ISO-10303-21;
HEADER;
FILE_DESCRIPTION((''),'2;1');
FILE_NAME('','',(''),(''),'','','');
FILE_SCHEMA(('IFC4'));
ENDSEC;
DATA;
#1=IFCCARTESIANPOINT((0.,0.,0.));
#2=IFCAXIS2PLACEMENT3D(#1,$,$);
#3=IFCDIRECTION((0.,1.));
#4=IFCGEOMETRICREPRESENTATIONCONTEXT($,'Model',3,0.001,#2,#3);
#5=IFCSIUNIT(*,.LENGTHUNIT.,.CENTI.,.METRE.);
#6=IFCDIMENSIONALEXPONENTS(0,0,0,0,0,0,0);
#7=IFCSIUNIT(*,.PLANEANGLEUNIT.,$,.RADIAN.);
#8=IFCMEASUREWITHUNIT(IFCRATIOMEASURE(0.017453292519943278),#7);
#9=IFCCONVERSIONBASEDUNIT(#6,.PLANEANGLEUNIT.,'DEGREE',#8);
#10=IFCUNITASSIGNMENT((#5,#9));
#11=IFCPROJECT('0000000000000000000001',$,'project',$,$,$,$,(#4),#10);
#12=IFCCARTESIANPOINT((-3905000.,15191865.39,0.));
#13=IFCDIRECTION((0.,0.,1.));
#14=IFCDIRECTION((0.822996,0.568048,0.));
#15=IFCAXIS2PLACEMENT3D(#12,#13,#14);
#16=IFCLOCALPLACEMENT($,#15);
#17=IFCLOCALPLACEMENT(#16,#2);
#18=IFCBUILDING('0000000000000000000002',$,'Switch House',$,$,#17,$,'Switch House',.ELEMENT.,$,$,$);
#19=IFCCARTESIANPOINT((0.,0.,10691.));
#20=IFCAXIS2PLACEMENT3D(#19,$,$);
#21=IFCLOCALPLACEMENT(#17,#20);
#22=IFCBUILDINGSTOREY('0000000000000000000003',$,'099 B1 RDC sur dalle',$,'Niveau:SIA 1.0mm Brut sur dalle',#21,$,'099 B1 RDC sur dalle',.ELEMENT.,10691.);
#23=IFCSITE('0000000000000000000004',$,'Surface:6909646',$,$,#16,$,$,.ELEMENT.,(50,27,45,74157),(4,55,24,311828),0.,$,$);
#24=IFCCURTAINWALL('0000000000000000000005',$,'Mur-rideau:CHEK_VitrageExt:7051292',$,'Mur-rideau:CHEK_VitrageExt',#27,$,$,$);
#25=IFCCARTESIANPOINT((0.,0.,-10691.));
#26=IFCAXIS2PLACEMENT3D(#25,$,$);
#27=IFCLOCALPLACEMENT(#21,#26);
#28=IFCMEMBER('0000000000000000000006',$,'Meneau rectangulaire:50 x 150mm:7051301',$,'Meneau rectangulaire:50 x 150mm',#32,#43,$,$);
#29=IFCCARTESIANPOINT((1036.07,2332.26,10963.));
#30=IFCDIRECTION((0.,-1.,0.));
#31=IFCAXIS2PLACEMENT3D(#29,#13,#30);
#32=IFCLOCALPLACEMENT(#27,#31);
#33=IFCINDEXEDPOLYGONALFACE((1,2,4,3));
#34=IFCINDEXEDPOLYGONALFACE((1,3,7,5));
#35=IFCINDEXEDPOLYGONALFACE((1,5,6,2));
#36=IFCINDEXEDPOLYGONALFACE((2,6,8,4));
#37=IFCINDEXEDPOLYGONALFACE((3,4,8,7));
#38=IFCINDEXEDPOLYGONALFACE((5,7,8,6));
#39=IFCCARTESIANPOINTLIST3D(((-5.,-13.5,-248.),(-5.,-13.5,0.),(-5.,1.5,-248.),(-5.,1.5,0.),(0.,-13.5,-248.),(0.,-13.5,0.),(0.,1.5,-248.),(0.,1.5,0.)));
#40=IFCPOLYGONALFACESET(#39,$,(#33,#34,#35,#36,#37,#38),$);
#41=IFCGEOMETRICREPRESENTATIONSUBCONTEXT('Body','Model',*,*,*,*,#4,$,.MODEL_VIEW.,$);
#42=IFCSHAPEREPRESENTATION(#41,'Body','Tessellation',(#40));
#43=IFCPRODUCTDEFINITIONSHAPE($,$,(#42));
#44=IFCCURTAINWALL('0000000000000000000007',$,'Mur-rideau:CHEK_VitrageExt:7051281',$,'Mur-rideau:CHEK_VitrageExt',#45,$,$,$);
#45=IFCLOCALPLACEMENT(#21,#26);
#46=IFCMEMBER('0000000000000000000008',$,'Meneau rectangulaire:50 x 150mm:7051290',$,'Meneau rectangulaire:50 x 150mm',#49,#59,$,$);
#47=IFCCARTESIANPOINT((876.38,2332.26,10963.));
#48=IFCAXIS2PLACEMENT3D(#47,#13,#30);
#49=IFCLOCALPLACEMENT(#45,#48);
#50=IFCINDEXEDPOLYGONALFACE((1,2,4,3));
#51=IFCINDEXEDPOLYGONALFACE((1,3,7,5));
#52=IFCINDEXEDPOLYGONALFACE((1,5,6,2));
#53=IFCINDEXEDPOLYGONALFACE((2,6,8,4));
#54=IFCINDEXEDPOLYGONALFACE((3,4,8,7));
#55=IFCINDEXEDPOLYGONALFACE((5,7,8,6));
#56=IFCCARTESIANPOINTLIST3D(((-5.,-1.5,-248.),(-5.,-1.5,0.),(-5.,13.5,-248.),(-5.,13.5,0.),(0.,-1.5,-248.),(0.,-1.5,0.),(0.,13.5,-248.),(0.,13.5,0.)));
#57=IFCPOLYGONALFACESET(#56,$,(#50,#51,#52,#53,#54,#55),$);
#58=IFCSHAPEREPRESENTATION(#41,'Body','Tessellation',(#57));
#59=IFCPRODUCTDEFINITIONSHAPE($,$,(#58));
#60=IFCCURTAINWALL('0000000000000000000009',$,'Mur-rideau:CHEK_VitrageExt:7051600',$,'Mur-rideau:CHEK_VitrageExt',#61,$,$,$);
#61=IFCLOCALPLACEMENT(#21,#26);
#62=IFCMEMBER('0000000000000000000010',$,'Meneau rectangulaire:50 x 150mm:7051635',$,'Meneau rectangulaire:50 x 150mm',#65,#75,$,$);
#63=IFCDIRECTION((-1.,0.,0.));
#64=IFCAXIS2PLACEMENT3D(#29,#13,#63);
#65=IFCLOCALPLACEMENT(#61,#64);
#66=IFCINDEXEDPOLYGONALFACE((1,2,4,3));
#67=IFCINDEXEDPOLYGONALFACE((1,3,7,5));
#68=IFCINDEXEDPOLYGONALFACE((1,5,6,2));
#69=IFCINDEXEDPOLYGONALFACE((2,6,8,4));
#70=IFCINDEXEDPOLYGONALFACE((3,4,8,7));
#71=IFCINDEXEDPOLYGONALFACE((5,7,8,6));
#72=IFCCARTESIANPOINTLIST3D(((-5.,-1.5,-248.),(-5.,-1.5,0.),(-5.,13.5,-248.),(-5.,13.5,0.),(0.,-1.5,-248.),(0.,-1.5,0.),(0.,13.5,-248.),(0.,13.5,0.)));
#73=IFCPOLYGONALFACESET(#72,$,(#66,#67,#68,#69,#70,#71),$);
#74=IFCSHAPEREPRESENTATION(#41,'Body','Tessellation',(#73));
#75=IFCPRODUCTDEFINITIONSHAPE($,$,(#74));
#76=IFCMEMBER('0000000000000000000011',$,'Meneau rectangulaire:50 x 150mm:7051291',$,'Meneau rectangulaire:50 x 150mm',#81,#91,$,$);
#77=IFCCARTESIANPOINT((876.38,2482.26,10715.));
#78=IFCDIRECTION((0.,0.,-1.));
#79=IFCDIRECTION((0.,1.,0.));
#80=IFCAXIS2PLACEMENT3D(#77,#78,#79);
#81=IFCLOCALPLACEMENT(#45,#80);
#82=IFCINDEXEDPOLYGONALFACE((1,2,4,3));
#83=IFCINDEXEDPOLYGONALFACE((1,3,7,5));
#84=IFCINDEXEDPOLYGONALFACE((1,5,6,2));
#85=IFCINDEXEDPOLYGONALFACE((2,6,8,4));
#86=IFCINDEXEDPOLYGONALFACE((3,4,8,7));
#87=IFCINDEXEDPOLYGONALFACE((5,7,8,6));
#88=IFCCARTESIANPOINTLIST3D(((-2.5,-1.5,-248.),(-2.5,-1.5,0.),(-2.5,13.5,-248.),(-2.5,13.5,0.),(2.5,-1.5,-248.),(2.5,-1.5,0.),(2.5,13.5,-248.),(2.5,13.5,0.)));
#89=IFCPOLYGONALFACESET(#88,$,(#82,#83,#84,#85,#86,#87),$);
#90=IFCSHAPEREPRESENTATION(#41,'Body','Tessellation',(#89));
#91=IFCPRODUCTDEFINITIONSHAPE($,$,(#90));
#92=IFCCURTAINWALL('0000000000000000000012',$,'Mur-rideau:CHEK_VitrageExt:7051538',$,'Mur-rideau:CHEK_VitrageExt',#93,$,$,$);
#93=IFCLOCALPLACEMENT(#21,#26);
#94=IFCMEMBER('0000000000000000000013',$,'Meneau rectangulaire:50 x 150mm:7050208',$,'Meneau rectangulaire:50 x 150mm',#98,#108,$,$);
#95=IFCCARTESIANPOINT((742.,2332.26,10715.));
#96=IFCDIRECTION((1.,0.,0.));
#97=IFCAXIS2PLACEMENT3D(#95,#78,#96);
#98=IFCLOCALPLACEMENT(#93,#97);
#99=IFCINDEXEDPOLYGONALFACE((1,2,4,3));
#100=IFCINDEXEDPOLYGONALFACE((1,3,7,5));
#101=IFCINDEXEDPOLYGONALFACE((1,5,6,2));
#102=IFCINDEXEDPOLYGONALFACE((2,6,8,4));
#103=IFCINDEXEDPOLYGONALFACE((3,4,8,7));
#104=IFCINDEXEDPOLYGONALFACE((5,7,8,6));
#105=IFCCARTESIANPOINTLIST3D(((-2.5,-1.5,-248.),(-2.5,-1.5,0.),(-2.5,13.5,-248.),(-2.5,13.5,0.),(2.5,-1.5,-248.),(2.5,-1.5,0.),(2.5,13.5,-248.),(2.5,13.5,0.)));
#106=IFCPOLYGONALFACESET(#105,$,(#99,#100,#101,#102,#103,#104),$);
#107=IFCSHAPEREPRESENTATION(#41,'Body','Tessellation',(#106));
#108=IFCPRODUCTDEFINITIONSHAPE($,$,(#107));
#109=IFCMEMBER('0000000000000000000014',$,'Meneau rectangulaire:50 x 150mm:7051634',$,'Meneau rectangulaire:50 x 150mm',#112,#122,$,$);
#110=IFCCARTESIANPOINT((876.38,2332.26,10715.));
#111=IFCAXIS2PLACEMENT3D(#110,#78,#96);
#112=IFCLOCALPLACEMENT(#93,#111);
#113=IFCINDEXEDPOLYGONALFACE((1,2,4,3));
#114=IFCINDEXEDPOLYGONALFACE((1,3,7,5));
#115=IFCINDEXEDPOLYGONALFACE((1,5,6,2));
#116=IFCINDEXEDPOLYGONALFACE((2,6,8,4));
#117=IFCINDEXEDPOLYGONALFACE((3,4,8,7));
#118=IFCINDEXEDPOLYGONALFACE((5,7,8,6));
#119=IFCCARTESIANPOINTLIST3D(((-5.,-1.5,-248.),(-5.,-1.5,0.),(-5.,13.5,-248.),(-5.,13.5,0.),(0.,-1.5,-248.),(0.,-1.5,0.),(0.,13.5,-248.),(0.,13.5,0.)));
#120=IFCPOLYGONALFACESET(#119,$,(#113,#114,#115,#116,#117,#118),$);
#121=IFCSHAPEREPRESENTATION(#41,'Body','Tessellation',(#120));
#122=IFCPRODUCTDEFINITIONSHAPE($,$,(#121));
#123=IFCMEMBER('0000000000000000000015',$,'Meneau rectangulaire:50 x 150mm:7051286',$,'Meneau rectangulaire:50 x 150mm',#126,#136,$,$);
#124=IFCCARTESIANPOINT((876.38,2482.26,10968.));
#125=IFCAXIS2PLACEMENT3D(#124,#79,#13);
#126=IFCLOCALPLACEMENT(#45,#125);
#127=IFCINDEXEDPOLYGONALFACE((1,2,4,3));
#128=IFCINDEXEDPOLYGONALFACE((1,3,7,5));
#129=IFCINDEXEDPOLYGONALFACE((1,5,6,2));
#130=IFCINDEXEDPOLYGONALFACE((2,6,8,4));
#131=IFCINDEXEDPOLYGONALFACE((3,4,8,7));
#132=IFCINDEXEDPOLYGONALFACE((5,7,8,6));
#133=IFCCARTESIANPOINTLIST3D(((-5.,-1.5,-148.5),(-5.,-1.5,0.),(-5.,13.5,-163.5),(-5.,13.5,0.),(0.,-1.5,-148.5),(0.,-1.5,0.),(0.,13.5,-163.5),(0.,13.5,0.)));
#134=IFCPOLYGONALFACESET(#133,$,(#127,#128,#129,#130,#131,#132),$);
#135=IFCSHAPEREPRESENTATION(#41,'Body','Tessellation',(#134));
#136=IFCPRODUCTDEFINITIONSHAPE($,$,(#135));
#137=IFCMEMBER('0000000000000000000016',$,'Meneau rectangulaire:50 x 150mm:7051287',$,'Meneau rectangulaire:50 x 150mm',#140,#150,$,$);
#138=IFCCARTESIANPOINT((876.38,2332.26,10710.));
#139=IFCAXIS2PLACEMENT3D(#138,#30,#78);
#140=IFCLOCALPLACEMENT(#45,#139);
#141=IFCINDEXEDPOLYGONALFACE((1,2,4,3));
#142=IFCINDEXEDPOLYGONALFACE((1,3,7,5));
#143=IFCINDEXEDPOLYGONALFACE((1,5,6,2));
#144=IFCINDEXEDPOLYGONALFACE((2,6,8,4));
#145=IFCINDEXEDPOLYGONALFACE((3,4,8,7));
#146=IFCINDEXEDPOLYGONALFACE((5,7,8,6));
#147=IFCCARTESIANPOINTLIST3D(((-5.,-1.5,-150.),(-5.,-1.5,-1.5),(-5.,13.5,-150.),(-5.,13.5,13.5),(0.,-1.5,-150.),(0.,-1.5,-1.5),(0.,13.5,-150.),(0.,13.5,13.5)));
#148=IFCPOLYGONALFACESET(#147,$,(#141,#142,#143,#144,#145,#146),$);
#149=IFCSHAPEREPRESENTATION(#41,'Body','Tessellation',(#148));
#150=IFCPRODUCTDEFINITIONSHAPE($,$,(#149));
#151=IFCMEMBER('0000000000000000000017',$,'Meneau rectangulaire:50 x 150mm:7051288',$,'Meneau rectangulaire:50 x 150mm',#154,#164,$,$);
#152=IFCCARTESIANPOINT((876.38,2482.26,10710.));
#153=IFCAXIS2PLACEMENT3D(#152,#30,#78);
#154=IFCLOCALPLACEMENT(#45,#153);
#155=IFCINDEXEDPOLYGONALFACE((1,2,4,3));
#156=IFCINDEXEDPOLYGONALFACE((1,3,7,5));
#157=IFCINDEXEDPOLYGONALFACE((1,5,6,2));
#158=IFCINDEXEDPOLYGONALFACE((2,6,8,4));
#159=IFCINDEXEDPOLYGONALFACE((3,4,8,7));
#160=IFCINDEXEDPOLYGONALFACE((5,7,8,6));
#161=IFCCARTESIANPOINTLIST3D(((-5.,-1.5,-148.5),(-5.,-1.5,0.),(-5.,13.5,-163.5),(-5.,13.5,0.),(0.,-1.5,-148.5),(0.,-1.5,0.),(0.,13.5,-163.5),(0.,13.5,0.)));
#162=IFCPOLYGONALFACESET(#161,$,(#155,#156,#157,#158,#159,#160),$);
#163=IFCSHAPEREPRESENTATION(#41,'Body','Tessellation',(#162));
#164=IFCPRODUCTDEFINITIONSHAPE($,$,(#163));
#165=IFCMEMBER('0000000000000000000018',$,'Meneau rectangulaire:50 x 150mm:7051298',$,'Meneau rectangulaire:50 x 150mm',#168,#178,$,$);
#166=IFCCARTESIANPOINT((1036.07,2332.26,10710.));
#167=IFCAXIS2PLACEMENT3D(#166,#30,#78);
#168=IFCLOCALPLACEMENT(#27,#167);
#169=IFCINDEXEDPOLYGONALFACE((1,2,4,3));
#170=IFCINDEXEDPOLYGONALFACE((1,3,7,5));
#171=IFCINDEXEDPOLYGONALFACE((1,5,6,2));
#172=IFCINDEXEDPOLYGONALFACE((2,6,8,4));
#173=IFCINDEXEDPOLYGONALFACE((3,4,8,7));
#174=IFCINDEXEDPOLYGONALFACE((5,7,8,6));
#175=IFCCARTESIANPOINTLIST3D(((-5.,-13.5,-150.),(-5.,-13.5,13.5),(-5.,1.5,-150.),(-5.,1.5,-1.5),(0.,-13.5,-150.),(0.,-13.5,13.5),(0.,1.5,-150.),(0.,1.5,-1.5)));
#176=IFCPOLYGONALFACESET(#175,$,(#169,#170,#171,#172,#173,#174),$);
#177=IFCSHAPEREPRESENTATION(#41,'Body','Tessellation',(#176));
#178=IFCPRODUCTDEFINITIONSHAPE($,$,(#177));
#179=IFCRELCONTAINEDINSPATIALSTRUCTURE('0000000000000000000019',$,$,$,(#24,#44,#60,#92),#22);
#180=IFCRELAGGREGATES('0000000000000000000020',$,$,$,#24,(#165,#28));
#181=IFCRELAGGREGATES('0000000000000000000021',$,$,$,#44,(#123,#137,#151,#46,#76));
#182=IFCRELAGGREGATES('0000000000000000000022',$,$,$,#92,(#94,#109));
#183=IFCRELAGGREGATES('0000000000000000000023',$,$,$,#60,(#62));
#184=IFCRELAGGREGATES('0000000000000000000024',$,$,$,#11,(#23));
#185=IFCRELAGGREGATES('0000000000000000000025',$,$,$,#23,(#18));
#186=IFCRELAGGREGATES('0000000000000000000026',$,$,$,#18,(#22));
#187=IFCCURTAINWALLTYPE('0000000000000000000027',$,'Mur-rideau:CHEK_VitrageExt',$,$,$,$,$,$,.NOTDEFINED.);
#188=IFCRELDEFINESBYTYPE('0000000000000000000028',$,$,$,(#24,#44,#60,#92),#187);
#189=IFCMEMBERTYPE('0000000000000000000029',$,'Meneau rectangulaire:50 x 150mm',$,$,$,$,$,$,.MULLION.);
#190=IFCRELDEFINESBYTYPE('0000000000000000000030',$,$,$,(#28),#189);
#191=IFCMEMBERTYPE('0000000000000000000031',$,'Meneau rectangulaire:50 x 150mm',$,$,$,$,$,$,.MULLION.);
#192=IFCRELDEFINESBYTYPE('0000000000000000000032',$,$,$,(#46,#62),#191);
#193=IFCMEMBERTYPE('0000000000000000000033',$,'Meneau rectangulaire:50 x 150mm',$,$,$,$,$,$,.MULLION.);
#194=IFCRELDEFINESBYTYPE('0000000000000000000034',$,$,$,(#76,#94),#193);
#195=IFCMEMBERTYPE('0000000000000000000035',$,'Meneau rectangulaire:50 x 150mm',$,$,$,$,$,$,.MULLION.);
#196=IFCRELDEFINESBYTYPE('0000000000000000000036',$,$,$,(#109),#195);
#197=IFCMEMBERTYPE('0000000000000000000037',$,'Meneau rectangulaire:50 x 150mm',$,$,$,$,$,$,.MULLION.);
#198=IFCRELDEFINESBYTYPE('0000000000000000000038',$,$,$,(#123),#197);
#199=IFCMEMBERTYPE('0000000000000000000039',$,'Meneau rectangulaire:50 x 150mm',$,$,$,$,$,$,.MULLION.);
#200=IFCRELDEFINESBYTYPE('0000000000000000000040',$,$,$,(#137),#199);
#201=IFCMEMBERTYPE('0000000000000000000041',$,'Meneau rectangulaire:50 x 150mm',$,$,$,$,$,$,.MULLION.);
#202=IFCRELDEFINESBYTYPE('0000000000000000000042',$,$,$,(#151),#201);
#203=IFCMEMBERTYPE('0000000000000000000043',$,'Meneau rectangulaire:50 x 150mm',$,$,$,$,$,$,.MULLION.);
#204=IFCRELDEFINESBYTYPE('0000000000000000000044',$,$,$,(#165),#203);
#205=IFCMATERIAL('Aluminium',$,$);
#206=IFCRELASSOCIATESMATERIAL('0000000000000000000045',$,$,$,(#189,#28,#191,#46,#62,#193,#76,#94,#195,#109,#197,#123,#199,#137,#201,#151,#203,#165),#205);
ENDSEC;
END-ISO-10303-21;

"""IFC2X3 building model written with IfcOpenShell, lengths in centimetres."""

from ifc_helpers import new_model, entity, si_unit, converted_unit, direction, frame, origin, origin_2d_with_axis, place, context, subcontext, project, spatial, rectangle, extrude, clip, halfspace, source, transform, mapped, material, type_object, type_shapes, element, aggregate, save


model = new_model("IFC2X3")

# Units and contexts
model_context = context("Model", 3, precision=0.001, world=origin(), true_north=direction((0.0, 1.0)))
body_context = subcontext(model_context, "Body", "Model", "MODEL_VIEW")
ifc_project = project(units=[si_unit("LENGTHUNIT", "METRE", prefix="CENTI"), converted_unit("PLANEANGLEUNIT", "DEGREE", entity("IfcRatioMeasure", 0.017453292519943278), si_unit("PLANEANGLEUNIT", "RADIAN"), dimensions=[0, 0, 0, 0, 0, 0, 0])], contexts=[model_context])

# Site, building, storey
site_placement = place(None, frame((-3905000.0, 15191865.39, 0.0), z_axis=(0.0, 0.0, 1.0), x_axis=(0.822996, 0.568048, 0.0)))
site = spatial("IfcSite", under=ifc_project, at=site_placement, Name="Surface:6909646", CompositionType="ELEMENT", RefLatitude=(50, 27, 45, 74157), RefLongitude=(4, 55, 24, 311828), RefElevation=0.0)
building_placement = place(site_placement, origin())
building = spatial("IfcBuilding", under=site, at=building_placement, Name="Switch House", LongName="Switch House", CompositionType="ELEMENT")
storey_placement = place(building_placement, frame((0.0, 0.0, 10691.0)))
storey = spatial("IfcBuildingStorey", under=building, at=storey_placement, Name="099 B1 RDC sur dalle", ObjectType="Niveau:SIA 1.0mm Brut sur dalle", LongName="099 B1 RDC sur dalle", CompositionType="ELEMENT", Elevation=10691.0)

# Curtain walls, members
curtain_wall_type = type_object("IfcCurtainWallType", Name="Mur-rideau:CHEK_VitrageExt", PredefinedType="NOTDEFINED")
curtain_wall_1_placement = place(storey_placement, frame((0.0, 0.0, -10691.0)))
curtain_wall_1 = element("IfcCurtainWall", 1, at=curtain_wall_1_placement, inside=storey, type_object=curtain_wall_type, Name="Mur-rideau:CHEK_VitrageExt:7051292", ObjectType="Mur-rideau:CHEK_VitrageExt")
ifc_material_1 = material(Name="Aluminium")
member_type_1 = type_object("IfcMemberType", Name="Meneau rectangulaire:50 x 150mm", PredefinedType="MULLION", material=ifc_material_1)
shared_shape_1 = source(origin(), body_context, "Body", "SweptSolid", [
    extrude(rectangle(XDim=15.0, YDim=5.0, at=origin_2d_with_axis()), frame((-2.5, -6.0, -248.0), z_axis=(0.0, 0.0, 1.0), x_axis=(0.0, -1.0, 0.0)), (0.0, 0.0, 1.0), 248.0),
])
type_shapes(member_type_1, [shared_shape_1])
member_1_placement = place(curtain_wall_1_placement, frame((1036.07, 2332.26, 10963.0), z_axis=(0.0, 0.0, 1.0), x_axis=(0.0, -1.0, 0.0)))
member_1 = element("IfcMember", 2, at=member_1_placement, type_object=member_type_1, material=ifc_material_1, Name="Meneau rectangulaire:50 x 150mm:7051301", ObjectType="Meneau rectangulaire:50 x 150mm", context=body_context, shape_type="MappedRepresentation", body=[
    mapped(shared_shape_1, transform((0.0, 0.0, 0.0), scale=1.0)),
])
curtain_wall_2_placement = place(storey_placement, frame((0.0, 0.0, -10691.0)))
curtain_wall_2 = element("IfcCurtainWall", 3, at=curtain_wall_2_placement, inside=storey, type_object=curtain_wall_type, Name="Mur-rideau:CHEK_VitrageExt:7051281", ObjectType="Mur-rideau:CHEK_VitrageExt")
member_type_2 = type_object("IfcMemberType", Name="Meneau rectangulaire:50 x 150mm", PredefinedType="MULLION", material=ifc_material_1)
shared_shape_2 = source(origin(), body_context, "Body", "SweptSolid", [
    extrude(rectangle(XDim=15.0, YDim=5.0, at=origin_2d_with_axis()), frame((-2.5, 6.0, -248.0), z_axis=(0.0, 0.0, 1.0), x_axis=(0.0, -1.0, 0.0)), (0.0, 0.0, 1.0), 248.0),
])
type_shapes(member_type_2, [shared_shape_2])
member_2_placement = place(curtain_wall_2_placement, frame((876.38, 2332.26, 10963.0), z_axis=(0.0, 0.0, 1.0), x_axis=(0.0, -1.0, 0.0)))
member_2 = element("IfcMember", 4, at=member_2_placement, type_object=member_type_2, material=ifc_material_1, Name="Meneau rectangulaire:50 x 150mm:7051290", ObjectType="Meneau rectangulaire:50 x 150mm", context=body_context, shape_type="MappedRepresentation", body=[
    mapped(shared_shape_2, transform((0.0, 0.0, 0.0), scale=1.0)),
])
curtain_wall_3_placement = place(storey_placement, frame((0.0, 0.0, -10691.0)))
curtain_wall_3 = element("IfcCurtainWall", 5, at=curtain_wall_3_placement, inside=storey, type_object=curtain_wall_type, Name="Mur-rideau:CHEK_VitrageExt:7051600", ObjectType="Mur-rideau:CHEK_VitrageExt")
member_3_placement = place(curtain_wall_3_placement, frame((1036.07, 2332.26, 10963.0), z_axis=(0.0, 0.0, 1.0), x_axis=(-1.0, 0.0, 0.0)))
member_3 = element("IfcMember", 6, at=member_3_placement, type_object=member_type_2, material=ifc_material_1, Name="Meneau rectangulaire:50 x 150mm:7051635", ObjectType="Meneau rectangulaire:50 x 150mm", context=body_context, shape_type="MappedRepresentation", body=[
    mapped(shared_shape_2, transform((0.0, 0.0, 0.0), scale=1.0)),
])

# Member
member_type_3 = type_object("IfcMemberType", Name="Meneau rectangulaire:50 x 150mm", PredefinedType="MULLION", material=ifc_material_1)
shared_shape_3 = source(origin(), body_context, "Body", "SweptSolid", [
    extrude(rectangle(XDim=15.0, YDim=5.0, at=origin_2d_with_axis()), frame((0.0, 6.0, -248.0), z_axis=(0.0, 0.0, 1.0), x_axis=(0.0, -1.0, 0.0)), (0.0, 0.0, 1.0), 248.0),
])
type_shapes(member_type_3, [shared_shape_3])
member_4_placement = place(curtain_wall_2_placement, frame((876.38, 2482.26, 10715.0), z_axis=(0.0, 0.0, -1.0), x_axis=(0.0, 1.0, 0.0)))
member_4 = element("IfcMember", 7, at=member_4_placement, type_object=member_type_3, material=ifc_material_1, Name="Meneau rectangulaire:50 x 150mm:7051291", ObjectType="Meneau rectangulaire:50 x 150mm", context=body_context, shape_type="MappedRepresentation", body=[
    mapped(shared_shape_3, transform((0.0, 0.0, 0.0), scale=1.0)),
])

# Curtain wall, members
curtain_wall_4_placement = place(storey_placement, frame((0.0, 0.0, -10691.0)))
curtain_wall_4 = element("IfcCurtainWall", 8, at=curtain_wall_4_placement, inside=storey, type_object=curtain_wall_type, Name="Mur-rideau:CHEK_VitrageExt:7051538", ObjectType="Mur-rideau:CHEK_VitrageExt")
member_5_placement = place(curtain_wall_4_placement, frame((742.0, 2332.26, 10715.0), z_axis=(0.0, 0.0, -1.0), x_axis=(1.0, 0.0, 0.0)))
member_5 = element("IfcMember", 9, at=member_5_placement, type_object=member_type_3, material=ifc_material_1, Name="Meneau rectangulaire:50 x 150mm:7050208", ObjectType="Meneau rectangulaire:50 x 150mm", context=body_context, shape_type="MappedRepresentation", body=[
    mapped(shared_shape_3, transform((0.0, 0.0, 0.0), scale=1.0)),
])
member_type_4 = type_object("IfcMemberType", Name="Meneau rectangulaire:50 x 150mm", PredefinedType="MULLION", material=ifc_material_1)
shared_shape_4 = source(origin(), body_context, "Body", "SweptSolid", [
    extrude(rectangle(XDim=15.0, YDim=5.0, at=origin_2d_with_axis()), frame((-2.5, 6.0, -248.0), z_axis=(0.0, 0.0, 1.0), x_axis=(0.0, -1.0, 0.0)), (0.0, 0.0, 1.0), 248.0),
])
type_shapes(member_type_4, [shared_shape_4])
member_6_placement = place(curtain_wall_4_placement, frame((876.38, 2332.26, 10715.0), z_axis=(0.0, 0.0, -1.0), x_axis=(1.0, 0.0, 0.0)))
member_6 = element("IfcMember", 10, at=member_6_placement, type_object=member_type_4, material=ifc_material_1, Name="Meneau rectangulaire:50 x 150mm:7051634", ObjectType="Meneau rectangulaire:50 x 150mm", context=body_context, shape_type="MappedRepresentation", body=[
    mapped(shared_shape_4, transform((0.0, 0.0, 0.0), scale=1.0)),
])

# Members
member_type_5 = type_object("IfcMemberType", Name="Meneau rectangulaire:50 x 150mm", PredefinedType="MULLION", material=ifc_material_1)
shared_shape_5 = source(origin(), body_context, "Body", "SweptSolid", [
    clip(extrude(rectangle(XDim=15.0, YDim=5.0, at=origin_2d_with_axis()), frame((-2.5, 6.0, -163.5), z_axis=(0.0, 0.0, 1.0), x_axis=(0.0, -1.0, 0.0)), (0.0, 0.0, 1.0), 163.5), halfspace(frame((30.48, 0.0, -150.0), z_axis=(0.0, -0.707107, -0.707107), x_axis=(0.0, -0.707107, 0.707107)), False)),
])
type_shapes(member_type_5, [shared_shape_5])
member_7_placement = place(curtain_wall_2_placement, frame((876.38, 2482.26, 10968.0), z_axis=(0.0, 1.0, 0.0), x_axis=(0.0, 0.0, 1.0)))
member_7 = element("IfcMember", 11, at=member_7_placement, type_object=member_type_5, material=ifc_material_1, Name="Meneau rectangulaire:50 x 150mm:7051286", ObjectType="Meneau rectangulaire:50 x 150mm", context=body_context, shape_type="MappedRepresentation", body=[
    mapped(shared_shape_5, transform((0.0, 0.0, 0.0), scale=1.0)),
])
member_type_6 = type_object("IfcMemberType", Name="Meneau rectangulaire:50 x 150mm", PredefinedType="MULLION", material=ifc_material_1)
shared_shape_6 = source(origin(), body_context, "Body", "SweptSolid", [
    clip(extrude(rectangle(XDim=15.0, YDim=5.0, at=origin_2d_with_axis()), frame((-2.5, 6.0, -150.0), z_axis=(0.0, 0.0, 1.0), x_axis=(0.0, -1.0, 0.0)), (0.0, 0.0, 1.0), 163.5), halfspace(frame((30.48, 0.0, 0.0), z_axis=(0.0, -0.707107, 0.707107), x_axis=(0.0, -0.707107, -0.707107)), False)),
])
type_shapes(member_type_6, [shared_shape_6])
member_8_placement = place(curtain_wall_2_placement, frame((876.38, 2332.26, 10710.0), z_axis=(0.0, -1.0, 0.0), x_axis=(0.0, 0.0, -1.0)))
member_8 = element("IfcMember", 12, at=member_8_placement, type_object=member_type_6, material=ifc_material_1, Name="Meneau rectangulaire:50 x 150mm:7051287", ObjectType="Meneau rectangulaire:50 x 150mm", context=body_context, shape_type="MappedRepresentation", body=[
    mapped(shared_shape_6, transform((0.0, 0.0, 0.0), scale=1.0)),
])
member_type_7 = type_object("IfcMemberType", Name="Meneau rectangulaire:50 x 150mm", PredefinedType="MULLION", material=ifc_material_1)
shared_shape_7 = source(origin(), body_context, "Body", "SweptSolid", [
    clip(extrude(rectangle(XDim=15.0, YDim=5.0, at=origin_2d_with_axis()), frame((-2.5, 6.0, -163.5), z_axis=(0.0, 0.0, 1.0), x_axis=(0.0, -1.0, 0.0)), (0.0, 0.0, 1.0), 163.5), halfspace(frame((30.48, 0.0, -150.0), z_axis=(0.0, -0.707107, -0.707107), x_axis=(0.0, -0.707107, 0.707107)), False)),
])
type_shapes(member_type_7, [shared_shape_7])
member_9_placement = place(curtain_wall_2_placement, frame((876.38, 2482.26, 10710.0), z_axis=(0.0, -1.0, 0.0), x_axis=(0.0, 0.0, -1.0)))
member_9 = element("IfcMember", 13, at=member_9_placement, type_object=member_type_7, material=ifc_material_1, Name="Meneau rectangulaire:50 x 150mm:7051288", ObjectType="Meneau rectangulaire:50 x 150mm", context=body_context, shape_type="MappedRepresentation", body=[
    mapped(shared_shape_7, transform((0.0, 0.0, 0.0), scale=1.0)),
])
member_type_8 = type_object("IfcMemberType", Name="Meneau rectangulaire:50 x 150mm", PredefinedType="MULLION", material=ifc_material_1)
shared_shape_8 = source(origin(), body_context, "Body", "SweptSolid", [
    clip(extrude(rectangle(XDim=15.0, YDim=5.0, at=origin_2d_with_axis()), frame((-2.5, -6.0, -150.0), z_axis=(0.0, 0.0, 1.0), x_axis=(0.0, -1.0, 0.0)), (0.0, 0.0, 1.0), 163.5), halfspace(frame((-30.48, 0.0, 0.0), z_axis=(0.0, 0.707107, 0.707107), x_axis=(0.0, 0.707107, -0.707107)), False)),
])
type_shapes(member_type_8, [shared_shape_8])
member_10_placement = place(curtain_wall_1_placement, frame((1036.07, 2332.26, 10710.0), z_axis=(0.0, -1.0, 0.0), x_axis=(0.0, 0.0, -1.0)))
member_10 = element("IfcMember", 14, at=member_10_placement, type_object=member_type_8, material=ifc_material_1, Name="Meneau rectangulaire:50 x 150mm:7051298", ObjectType="Meneau rectangulaire:50 x 150mm", context=body_context, shape_type="MappedRepresentation", body=[
    mapped(shared_shape_8, transform((0.0, 0.0, 0.0), scale=1.0)),
])
aggregate(curtain_wall_1, [member_10, member_1])

aggregate(curtain_wall_2, [member_7, member_8, member_9, member_2, member_4])
aggregate(curtain_wall_4, [member_5, member_6])
aggregate(curtain_wall_3, [member_3])

save(model, "model.ifc")
